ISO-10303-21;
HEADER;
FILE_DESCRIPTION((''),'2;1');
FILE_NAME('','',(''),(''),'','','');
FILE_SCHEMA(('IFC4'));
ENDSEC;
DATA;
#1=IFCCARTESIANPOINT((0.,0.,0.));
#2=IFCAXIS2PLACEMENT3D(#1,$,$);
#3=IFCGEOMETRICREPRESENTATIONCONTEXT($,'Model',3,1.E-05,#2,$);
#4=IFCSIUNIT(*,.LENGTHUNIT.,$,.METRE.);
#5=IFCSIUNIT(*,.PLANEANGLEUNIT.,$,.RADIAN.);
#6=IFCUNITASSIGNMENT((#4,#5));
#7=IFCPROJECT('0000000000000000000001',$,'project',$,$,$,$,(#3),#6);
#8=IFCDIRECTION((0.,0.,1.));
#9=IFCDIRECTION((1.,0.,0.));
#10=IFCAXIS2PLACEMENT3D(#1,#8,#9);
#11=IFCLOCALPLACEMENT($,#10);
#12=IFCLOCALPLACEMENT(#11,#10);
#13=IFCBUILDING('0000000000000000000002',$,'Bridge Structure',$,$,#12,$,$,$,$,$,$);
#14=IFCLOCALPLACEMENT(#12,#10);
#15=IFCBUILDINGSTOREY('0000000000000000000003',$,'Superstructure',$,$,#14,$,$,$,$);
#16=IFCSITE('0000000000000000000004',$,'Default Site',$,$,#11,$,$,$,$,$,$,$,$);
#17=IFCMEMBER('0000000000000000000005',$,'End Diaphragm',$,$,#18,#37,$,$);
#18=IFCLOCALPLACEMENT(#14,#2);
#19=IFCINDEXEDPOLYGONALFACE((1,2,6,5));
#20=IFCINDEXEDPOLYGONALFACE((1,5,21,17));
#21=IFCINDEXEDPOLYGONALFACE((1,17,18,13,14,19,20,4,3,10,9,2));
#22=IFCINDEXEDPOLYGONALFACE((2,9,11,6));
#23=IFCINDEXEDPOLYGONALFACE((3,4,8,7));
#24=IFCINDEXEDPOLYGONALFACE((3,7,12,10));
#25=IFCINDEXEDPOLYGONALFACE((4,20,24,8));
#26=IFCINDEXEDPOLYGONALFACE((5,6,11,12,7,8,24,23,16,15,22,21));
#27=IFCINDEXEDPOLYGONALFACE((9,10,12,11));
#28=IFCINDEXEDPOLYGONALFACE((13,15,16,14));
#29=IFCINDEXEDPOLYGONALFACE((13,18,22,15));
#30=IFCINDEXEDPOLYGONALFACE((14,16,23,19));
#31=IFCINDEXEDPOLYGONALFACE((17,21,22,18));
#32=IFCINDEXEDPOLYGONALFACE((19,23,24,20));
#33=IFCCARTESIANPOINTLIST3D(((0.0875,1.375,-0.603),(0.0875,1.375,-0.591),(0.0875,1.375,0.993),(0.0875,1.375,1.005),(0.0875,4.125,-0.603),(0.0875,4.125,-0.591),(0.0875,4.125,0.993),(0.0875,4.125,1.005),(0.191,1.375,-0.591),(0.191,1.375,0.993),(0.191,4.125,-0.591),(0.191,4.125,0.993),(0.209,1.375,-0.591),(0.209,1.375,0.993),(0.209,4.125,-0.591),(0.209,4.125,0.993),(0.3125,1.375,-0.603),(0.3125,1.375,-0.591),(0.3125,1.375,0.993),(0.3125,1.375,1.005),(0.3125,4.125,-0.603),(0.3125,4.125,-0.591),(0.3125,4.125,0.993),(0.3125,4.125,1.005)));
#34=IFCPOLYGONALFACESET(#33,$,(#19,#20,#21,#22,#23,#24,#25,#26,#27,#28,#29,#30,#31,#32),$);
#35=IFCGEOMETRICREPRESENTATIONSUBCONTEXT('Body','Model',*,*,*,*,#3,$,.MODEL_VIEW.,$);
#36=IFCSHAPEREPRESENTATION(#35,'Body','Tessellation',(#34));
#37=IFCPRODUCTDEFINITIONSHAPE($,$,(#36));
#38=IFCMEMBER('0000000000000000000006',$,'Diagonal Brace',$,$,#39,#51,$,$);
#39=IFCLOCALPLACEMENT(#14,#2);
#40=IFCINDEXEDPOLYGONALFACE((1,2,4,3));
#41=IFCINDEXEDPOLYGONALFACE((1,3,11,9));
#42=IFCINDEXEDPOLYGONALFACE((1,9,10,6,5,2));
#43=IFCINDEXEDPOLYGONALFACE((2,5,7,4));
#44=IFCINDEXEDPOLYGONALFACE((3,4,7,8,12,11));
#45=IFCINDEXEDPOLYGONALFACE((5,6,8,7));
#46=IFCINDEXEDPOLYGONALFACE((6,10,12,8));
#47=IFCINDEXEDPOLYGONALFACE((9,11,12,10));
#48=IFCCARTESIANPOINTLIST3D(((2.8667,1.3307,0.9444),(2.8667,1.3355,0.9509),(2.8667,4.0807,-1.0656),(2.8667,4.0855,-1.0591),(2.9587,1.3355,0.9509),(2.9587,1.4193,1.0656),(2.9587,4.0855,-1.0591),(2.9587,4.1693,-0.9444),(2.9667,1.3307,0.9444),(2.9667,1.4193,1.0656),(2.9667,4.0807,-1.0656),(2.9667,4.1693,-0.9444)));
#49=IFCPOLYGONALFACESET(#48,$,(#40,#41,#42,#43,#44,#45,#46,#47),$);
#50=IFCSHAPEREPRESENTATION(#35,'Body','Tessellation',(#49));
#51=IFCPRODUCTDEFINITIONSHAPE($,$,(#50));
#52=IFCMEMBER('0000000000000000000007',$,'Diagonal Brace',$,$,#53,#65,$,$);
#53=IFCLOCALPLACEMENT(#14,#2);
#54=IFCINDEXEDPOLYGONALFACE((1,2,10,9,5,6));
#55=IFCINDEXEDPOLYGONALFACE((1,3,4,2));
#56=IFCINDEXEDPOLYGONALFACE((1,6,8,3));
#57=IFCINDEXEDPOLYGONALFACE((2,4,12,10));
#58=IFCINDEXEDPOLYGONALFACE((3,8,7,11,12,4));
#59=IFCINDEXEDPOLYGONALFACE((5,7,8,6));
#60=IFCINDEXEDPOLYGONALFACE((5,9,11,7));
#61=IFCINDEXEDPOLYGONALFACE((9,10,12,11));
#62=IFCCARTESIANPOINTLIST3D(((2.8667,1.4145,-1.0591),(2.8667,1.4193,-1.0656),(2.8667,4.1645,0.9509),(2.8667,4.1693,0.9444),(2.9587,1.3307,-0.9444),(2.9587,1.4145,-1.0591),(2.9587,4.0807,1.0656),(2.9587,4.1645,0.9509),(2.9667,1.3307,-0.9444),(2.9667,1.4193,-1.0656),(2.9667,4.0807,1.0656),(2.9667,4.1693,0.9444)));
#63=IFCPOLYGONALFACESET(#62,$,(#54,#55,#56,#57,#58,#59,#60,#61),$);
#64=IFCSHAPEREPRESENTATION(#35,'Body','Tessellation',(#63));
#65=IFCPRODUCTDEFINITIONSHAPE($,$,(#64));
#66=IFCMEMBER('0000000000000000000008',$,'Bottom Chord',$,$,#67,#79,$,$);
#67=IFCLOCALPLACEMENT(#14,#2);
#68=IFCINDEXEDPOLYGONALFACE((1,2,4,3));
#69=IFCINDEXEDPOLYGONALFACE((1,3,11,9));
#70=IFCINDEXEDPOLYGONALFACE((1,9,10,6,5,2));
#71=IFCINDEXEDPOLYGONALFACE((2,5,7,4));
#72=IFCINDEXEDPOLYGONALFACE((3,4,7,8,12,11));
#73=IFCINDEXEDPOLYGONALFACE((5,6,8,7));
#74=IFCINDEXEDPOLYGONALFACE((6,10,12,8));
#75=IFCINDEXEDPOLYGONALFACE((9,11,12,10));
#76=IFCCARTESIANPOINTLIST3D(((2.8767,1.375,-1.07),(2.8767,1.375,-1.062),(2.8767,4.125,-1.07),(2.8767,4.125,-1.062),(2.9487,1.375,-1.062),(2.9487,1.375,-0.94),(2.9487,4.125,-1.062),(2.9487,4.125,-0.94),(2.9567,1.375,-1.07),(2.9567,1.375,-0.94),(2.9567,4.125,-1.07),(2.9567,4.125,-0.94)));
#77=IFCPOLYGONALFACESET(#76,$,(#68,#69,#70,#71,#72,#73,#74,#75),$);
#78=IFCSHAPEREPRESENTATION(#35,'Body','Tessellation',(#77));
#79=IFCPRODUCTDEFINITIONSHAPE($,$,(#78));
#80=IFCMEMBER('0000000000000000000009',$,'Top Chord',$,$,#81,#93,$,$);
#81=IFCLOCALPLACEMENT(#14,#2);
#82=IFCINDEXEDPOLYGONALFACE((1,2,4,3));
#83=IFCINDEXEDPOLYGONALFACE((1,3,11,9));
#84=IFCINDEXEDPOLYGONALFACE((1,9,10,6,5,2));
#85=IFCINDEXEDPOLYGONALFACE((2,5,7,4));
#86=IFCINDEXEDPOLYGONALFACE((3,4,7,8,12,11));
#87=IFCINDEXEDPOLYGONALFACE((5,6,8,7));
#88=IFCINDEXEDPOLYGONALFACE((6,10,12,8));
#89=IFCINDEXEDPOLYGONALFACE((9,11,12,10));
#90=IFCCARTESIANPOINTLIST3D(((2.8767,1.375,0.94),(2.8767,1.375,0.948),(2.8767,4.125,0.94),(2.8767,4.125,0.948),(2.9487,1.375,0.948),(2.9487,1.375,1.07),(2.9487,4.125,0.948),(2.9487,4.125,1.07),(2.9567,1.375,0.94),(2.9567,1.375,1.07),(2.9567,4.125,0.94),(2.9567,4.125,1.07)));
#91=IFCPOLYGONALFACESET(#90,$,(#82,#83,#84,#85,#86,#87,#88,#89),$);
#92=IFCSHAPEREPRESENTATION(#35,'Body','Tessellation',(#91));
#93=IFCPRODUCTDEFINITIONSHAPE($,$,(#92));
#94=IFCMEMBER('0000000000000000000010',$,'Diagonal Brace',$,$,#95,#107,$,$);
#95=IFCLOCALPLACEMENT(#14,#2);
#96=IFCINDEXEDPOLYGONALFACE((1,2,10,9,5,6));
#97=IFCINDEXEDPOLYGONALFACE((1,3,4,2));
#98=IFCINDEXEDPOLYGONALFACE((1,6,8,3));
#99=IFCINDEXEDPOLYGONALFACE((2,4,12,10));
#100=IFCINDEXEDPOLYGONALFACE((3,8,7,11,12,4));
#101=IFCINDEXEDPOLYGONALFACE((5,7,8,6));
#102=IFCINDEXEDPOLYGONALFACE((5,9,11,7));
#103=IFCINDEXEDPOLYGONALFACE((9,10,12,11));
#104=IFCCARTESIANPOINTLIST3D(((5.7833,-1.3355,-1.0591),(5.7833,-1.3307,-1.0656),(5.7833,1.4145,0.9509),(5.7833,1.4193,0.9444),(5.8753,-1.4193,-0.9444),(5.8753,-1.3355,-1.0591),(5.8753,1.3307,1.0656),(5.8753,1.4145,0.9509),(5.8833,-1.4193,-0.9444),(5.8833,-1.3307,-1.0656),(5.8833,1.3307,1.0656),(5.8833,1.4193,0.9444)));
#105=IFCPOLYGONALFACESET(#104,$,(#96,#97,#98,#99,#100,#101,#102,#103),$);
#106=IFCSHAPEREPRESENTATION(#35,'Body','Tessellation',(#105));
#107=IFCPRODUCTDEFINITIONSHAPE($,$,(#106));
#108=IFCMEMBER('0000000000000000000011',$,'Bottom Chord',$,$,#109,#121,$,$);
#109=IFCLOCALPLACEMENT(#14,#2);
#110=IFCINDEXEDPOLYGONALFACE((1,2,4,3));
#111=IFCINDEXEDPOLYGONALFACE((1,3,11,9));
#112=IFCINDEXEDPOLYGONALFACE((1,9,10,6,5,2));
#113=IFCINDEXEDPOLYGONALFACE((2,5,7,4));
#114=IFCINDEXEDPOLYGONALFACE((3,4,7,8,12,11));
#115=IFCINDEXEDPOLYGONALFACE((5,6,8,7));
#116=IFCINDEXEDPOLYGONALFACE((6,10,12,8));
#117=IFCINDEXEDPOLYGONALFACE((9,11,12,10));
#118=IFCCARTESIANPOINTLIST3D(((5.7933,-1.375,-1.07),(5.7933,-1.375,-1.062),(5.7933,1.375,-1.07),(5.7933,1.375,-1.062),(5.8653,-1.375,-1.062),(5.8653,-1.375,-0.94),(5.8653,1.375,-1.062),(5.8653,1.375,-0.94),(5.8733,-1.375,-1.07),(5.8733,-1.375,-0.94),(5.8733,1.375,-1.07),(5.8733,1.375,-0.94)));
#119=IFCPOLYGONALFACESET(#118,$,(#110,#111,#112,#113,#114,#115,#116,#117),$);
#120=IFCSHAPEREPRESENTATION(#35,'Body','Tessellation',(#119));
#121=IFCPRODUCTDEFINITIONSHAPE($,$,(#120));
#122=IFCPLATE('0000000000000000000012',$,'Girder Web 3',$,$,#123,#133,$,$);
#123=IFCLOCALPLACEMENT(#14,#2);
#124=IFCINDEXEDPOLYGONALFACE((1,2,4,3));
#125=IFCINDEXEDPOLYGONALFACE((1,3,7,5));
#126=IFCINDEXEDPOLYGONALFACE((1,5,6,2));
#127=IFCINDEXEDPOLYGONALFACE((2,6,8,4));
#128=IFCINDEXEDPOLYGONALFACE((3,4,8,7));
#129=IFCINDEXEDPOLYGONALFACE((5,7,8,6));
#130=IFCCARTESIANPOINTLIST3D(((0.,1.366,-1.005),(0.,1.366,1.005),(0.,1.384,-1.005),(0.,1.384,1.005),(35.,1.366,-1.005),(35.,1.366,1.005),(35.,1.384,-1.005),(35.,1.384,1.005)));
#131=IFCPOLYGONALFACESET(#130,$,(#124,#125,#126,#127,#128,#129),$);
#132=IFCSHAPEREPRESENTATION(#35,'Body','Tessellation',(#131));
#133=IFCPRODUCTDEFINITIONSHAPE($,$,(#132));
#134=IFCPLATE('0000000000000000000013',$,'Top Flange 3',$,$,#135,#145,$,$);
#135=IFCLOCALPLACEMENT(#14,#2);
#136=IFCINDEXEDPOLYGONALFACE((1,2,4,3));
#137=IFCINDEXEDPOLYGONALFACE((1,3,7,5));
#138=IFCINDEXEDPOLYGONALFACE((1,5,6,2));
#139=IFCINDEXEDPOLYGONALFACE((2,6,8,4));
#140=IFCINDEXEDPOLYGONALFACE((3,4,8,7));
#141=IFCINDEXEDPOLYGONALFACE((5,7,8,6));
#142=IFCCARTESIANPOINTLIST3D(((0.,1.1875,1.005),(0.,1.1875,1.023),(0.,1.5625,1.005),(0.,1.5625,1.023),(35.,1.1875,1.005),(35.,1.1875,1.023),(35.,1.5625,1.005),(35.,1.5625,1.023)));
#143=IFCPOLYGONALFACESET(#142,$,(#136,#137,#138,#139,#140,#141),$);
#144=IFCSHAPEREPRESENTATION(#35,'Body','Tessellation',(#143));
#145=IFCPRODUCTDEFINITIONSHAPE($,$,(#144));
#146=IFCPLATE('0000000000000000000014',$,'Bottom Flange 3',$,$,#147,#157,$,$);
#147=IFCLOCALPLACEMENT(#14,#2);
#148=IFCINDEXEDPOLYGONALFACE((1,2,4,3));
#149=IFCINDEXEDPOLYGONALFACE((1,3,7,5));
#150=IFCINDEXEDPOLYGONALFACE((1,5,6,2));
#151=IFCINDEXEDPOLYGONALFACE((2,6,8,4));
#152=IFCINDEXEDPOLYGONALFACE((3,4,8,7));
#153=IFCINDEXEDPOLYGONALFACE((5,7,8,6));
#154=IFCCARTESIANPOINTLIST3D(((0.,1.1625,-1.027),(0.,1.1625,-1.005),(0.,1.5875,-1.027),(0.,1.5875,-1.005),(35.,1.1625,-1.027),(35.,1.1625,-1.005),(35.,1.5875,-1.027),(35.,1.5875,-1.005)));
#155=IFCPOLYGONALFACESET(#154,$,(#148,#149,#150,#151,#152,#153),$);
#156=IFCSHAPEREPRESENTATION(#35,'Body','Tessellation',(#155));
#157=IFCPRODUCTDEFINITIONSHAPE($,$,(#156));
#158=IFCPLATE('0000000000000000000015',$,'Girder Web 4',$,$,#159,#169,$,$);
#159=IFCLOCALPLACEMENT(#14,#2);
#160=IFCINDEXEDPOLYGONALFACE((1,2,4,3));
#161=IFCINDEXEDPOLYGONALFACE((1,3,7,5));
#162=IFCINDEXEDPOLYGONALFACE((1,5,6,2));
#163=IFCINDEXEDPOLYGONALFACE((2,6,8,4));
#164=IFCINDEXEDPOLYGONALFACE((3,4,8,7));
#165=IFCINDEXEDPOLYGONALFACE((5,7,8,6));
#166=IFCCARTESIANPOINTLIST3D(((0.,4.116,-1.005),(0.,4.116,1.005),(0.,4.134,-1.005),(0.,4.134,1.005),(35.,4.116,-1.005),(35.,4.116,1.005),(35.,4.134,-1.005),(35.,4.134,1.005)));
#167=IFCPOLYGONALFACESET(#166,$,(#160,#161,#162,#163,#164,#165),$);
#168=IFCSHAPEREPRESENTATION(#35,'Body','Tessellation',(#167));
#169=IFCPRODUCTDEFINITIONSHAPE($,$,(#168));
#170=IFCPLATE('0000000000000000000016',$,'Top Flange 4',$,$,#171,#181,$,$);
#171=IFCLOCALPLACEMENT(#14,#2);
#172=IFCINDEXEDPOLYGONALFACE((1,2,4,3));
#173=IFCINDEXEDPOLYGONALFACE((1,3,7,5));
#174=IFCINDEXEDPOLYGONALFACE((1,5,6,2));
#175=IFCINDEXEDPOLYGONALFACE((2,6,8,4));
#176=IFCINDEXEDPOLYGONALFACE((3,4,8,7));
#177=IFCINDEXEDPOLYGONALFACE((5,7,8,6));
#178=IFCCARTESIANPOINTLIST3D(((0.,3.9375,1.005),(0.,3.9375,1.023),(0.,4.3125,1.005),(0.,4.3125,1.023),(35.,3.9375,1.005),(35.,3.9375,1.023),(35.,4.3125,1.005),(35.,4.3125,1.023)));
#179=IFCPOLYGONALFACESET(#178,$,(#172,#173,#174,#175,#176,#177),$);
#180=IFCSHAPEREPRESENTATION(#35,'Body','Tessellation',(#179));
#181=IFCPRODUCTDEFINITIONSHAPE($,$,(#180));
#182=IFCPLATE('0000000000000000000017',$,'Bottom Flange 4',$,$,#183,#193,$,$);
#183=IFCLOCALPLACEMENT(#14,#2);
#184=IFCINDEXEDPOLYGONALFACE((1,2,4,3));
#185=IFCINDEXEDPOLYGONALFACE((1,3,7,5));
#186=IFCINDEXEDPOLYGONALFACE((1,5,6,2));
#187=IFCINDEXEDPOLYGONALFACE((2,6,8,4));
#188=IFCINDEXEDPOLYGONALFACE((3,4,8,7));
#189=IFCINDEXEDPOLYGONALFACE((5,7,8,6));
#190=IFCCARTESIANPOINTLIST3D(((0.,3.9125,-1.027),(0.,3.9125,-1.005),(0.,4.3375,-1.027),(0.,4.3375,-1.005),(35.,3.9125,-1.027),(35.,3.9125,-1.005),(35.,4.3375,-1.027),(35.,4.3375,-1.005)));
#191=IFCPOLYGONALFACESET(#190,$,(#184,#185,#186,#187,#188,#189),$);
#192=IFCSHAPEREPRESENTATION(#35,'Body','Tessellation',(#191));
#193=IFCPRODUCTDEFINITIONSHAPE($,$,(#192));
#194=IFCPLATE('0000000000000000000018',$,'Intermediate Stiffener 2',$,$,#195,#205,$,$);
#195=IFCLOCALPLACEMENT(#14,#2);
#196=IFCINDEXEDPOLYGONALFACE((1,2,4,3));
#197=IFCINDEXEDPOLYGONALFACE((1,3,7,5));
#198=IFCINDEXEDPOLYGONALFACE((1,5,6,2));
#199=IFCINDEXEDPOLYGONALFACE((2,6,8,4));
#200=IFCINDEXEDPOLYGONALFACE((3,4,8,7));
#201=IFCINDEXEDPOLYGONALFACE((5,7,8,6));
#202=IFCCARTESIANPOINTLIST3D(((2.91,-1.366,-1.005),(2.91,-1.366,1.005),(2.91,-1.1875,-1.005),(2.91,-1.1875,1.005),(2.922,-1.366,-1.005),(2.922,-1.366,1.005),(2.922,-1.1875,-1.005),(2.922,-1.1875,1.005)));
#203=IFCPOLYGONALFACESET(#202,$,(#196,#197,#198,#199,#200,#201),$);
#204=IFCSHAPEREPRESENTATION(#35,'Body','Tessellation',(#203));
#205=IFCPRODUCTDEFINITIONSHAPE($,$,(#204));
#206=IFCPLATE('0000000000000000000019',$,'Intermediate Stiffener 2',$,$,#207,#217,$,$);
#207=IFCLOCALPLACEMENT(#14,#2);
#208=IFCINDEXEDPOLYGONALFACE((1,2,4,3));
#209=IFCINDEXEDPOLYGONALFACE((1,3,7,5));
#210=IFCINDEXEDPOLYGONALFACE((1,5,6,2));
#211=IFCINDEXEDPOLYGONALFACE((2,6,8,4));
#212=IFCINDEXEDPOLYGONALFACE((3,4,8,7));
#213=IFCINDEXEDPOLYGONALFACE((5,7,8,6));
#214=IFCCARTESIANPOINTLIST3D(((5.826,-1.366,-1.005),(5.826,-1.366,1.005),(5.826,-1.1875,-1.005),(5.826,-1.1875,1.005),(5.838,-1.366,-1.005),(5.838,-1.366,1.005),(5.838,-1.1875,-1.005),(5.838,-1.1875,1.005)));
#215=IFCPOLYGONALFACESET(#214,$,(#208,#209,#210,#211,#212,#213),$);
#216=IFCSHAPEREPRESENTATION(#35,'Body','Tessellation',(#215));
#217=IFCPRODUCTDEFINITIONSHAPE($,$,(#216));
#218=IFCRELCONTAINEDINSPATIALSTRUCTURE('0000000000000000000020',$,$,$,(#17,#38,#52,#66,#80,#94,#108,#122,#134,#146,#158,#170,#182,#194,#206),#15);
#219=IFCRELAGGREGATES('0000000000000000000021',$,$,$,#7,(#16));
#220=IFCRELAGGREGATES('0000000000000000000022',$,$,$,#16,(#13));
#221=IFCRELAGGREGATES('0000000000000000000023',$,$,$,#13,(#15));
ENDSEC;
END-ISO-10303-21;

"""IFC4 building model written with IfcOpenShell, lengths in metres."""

from ifc_helpers import new_model, si_unit, frame, origin, origin_with_axes, origin_2d_with_axis, place, context, subcontext, project, spatial, rectangle, i_section, l_section, extrude, element, save


model = new_model("IFC4")

# Units and contexts
model_context = context("Model", 3, precision=1e-05, world=origin())
body_context = subcontext(model_context, "Body", "Model", "MODEL_VIEW")
ifc_project = project(units=[si_unit("LENGTHUNIT", "METRE"), si_unit("PLANEANGLEUNIT", "RADIAN")], contexts=[model_context])

# Site, building, storey
site_placement = place(None, origin_with_axes())
site = spatial("IfcSite", under=ifc_project, at=site_placement, Name="Default Site")
building_placement = place(site_placement, origin_with_axes())
building = spatial("IfcBuilding", under=site, at=building_placement, Name="Bridge Structure")
storey_placement = place(building_placement, origin_with_axes())
storey = spatial("IfcBuildingStorey", under=building, at=storey_placement, Name="Superstructure")

# Members
member_1_placement = place(storey_placement, frame((0.2, 1.375, 0.201), z_axis=(0.0, 1.0, 0.0), x_axis=(-1.0, 0.0, 0.0)))
element("IfcMember", 1, at=member_1_placement, inside=storey, Name="End Diaphragm", context=body_context, shape_type="SweptSolid", body=[
    extrude(i_section(OverallWidth=0.225, OverallDepth=1.608, WebThickness=0.018, FlangeThickness=0.012, at=origin_2d_with_axis()), origin_with_axes(), (0.0, 0.0, 1.0), 2.75),
])
for number, where, z_axis, x_axis, name in (
    (2, (2.9167, 1.375, 1.005), (0.0, 0.807337, -0.59009), (-1.0, 0.0, 0.0), "Diagonal Brace"),
    (3, (2.9167, 1.375, -1.005), (0.0, 0.807337, 0.59009), (-1.0, 0.0, 0.0), "Diagonal Brace"),
):
    element("IfcMember", number, at=place(storey_placement, frame(where, z_axis=z_axis, x_axis=x_axis)), inside=storey, Name=name, context=body_context, shape_type="SweptSolid", body=[
        extrude(l_section(Depth=0.15, Width=0.1, Thickness=0.008, at=origin_2d_with_axis()), origin_with_axes(), (0.0, 0.0, 1.0), 3.4063),
    ])
for number, where, z_axis, x_axis, name in (
    (4, (2.9167, 1.375, -1.005), (0.0, 1.0, 0.0), (-1.0, 0.0, 0.0), "Bottom Chord"),
    (5, (2.9167, 1.375, 1.005), (0.0, 1.0, 0.0), (-1.0, 0.0, 0.0), "Top Chord"),
):
    element("IfcMember", number, at=place(storey_placement, frame(where, z_axis=z_axis, x_axis=x_axis)), inside=storey, Name=name, context=body_context, shape_type="SweptSolid", body=[
        extrude(l_section(Depth=0.13, Width=0.08, Thickness=0.008, at=origin_2d_with_axis()), origin_with_axes(), (0.0, 0.0, 1.0), 2.75),
    ])
member_2_placement = place(storey_placement, frame((5.8333, -1.375, -1.005), z_axis=(0.0, 0.807337, 0.59009), x_axis=(-1.0, 0.0, 0.0)))
element("IfcMember", 6, at=member_2_placement, inside=storey, Name="Diagonal Brace", context=body_context, shape_type="SweptSolid", body=[
    extrude(l_section(Depth=0.15, Width=0.1, Thickness=0.008, at=origin_2d_with_axis()), origin_with_axes(), (0.0, 0.0, 1.0), 3.4063),
])
member_3_placement = place(storey_placement, frame((5.8333, -1.375, -1.005), z_axis=(0.0, 1.0, 0.0), x_axis=(-1.0, 0.0, 0.0)))
element("IfcMember", 7, at=member_3_placement, inside=storey, Name="Bottom Chord", context=body_context, shape_type="SweptSolid", body=[
    extrude(l_section(Depth=0.13, Width=0.08, Thickness=0.008, at=origin_2d_with_axis()), origin_with_axes(), (0.0, 0.0, 1.0), 2.75),
])

# Plates
plate_1_placement = place(storey_placement, frame((0.0, 1.375, 0.0), z_axis=(1.0, 0.0, 0.0), x_axis=(0.0, 1.0, 0.0)))
element("IfcPlate", 8, at=plate_1_placement, inside=storey, Name="Girder Web 3", context=body_context, shape_type="SweptSolid", body=[
    extrude(rectangle(XDim=0.018, YDim=2.01, at=origin_2d_with_axis()), origin_with_axes(), (0.0, 0.0, 1.0), 35.0),
])
plate_2_placement = place(storey_placement, frame((0.0, 1.375, 1.014), z_axis=(1.0, 0.0, 0.0), x_axis=(0.0, 1.0, 0.0)))
element("IfcPlate", 9, at=plate_2_placement, inside=storey, Name="Top Flange 3", context=body_context, shape_type="SweptSolid", body=[
    extrude(rectangle(XDim=0.375, YDim=0.018, at=origin_2d_with_axis()), origin_with_axes(), (0.0, 0.0, 1.0), 35.0),
])
plate_3_placement = place(storey_placement, frame((0.0, 1.375, -1.016), z_axis=(1.0, 0.0, 0.0), x_axis=(0.0, 1.0, 0.0)))
element("IfcPlate", 10, at=plate_3_placement, inside=storey, Name="Bottom Flange 3", context=body_context, shape_type="SweptSolid", body=[
    extrude(rectangle(XDim=0.425, YDim=0.022, at=origin_2d_with_axis()), origin_with_axes(), (0.0, 0.0, 1.0), 35.0),
])
plate_4_placement = place(storey_placement, frame((0.0, 4.125, 0.0), z_axis=(1.0, 0.0, 0.0), x_axis=(0.0, 1.0, 0.0)))
element("IfcPlate", 11, at=plate_4_placement, inside=storey, Name="Girder Web 4", context=body_context, shape_type="SweptSolid", body=[
    extrude(rectangle(XDim=0.018, YDim=2.01, at=origin_2d_with_axis()), origin_with_axes(), (0.0, 0.0, 1.0), 35.0),
])
plate_5_placement = place(storey_placement, frame((0.0, 4.125, 1.014), z_axis=(1.0, 0.0, 0.0), x_axis=(0.0, 1.0, 0.0)))
element("IfcPlate", 12, at=plate_5_placement, inside=storey, Name="Top Flange 4", context=body_context, shape_type="SweptSolid", body=[
    extrude(rectangle(XDim=0.375, YDim=0.018, at=origin_2d_with_axis()), origin_with_axes(), (0.0, 0.0, 1.0), 35.0),
])
plate_6_placement = place(storey_placement, frame((0.0, 4.125, -1.016), z_axis=(1.0, 0.0, 0.0), x_axis=(0.0, 1.0, 0.0)))
element("IfcPlate", 13, at=plate_6_placement, inside=storey, Name="Bottom Flange 4", context=body_context, shape_type="SweptSolid", body=[
    extrude(rectangle(XDim=0.425, YDim=0.022, at=origin_2d_with_axis()), origin_with_axes(), (0.0, 0.0, 1.0), 35.0),
])
for number, where, z_axis, x_axis, name in (
    (14, (2.916, -1.2768, -1.005), (0.0, 0.0, 1.0), (1.0, 0.0, 0.0), "Intermediate Stiffener 2"),
    (15, (5.832, -1.2768, -1.005), (0.0, 0.0, 1.0), (1.0, 0.0, 0.0), "Intermediate Stiffener 2"),
):
    element("IfcPlate", number, at=place(storey_placement, frame(where, z_axis=z_axis, x_axis=x_axis)), inside=storey, Name=name, context=body_context, shape_type="SweptSolid", body=[
        extrude(rectangle(XDim=0.012, YDim=0.1785, at=origin_2d_with_axis()), origin_with_axes(), (0.0, 0.0, 1.0), 2.01),
    ])

save(model, "model.ifc")
